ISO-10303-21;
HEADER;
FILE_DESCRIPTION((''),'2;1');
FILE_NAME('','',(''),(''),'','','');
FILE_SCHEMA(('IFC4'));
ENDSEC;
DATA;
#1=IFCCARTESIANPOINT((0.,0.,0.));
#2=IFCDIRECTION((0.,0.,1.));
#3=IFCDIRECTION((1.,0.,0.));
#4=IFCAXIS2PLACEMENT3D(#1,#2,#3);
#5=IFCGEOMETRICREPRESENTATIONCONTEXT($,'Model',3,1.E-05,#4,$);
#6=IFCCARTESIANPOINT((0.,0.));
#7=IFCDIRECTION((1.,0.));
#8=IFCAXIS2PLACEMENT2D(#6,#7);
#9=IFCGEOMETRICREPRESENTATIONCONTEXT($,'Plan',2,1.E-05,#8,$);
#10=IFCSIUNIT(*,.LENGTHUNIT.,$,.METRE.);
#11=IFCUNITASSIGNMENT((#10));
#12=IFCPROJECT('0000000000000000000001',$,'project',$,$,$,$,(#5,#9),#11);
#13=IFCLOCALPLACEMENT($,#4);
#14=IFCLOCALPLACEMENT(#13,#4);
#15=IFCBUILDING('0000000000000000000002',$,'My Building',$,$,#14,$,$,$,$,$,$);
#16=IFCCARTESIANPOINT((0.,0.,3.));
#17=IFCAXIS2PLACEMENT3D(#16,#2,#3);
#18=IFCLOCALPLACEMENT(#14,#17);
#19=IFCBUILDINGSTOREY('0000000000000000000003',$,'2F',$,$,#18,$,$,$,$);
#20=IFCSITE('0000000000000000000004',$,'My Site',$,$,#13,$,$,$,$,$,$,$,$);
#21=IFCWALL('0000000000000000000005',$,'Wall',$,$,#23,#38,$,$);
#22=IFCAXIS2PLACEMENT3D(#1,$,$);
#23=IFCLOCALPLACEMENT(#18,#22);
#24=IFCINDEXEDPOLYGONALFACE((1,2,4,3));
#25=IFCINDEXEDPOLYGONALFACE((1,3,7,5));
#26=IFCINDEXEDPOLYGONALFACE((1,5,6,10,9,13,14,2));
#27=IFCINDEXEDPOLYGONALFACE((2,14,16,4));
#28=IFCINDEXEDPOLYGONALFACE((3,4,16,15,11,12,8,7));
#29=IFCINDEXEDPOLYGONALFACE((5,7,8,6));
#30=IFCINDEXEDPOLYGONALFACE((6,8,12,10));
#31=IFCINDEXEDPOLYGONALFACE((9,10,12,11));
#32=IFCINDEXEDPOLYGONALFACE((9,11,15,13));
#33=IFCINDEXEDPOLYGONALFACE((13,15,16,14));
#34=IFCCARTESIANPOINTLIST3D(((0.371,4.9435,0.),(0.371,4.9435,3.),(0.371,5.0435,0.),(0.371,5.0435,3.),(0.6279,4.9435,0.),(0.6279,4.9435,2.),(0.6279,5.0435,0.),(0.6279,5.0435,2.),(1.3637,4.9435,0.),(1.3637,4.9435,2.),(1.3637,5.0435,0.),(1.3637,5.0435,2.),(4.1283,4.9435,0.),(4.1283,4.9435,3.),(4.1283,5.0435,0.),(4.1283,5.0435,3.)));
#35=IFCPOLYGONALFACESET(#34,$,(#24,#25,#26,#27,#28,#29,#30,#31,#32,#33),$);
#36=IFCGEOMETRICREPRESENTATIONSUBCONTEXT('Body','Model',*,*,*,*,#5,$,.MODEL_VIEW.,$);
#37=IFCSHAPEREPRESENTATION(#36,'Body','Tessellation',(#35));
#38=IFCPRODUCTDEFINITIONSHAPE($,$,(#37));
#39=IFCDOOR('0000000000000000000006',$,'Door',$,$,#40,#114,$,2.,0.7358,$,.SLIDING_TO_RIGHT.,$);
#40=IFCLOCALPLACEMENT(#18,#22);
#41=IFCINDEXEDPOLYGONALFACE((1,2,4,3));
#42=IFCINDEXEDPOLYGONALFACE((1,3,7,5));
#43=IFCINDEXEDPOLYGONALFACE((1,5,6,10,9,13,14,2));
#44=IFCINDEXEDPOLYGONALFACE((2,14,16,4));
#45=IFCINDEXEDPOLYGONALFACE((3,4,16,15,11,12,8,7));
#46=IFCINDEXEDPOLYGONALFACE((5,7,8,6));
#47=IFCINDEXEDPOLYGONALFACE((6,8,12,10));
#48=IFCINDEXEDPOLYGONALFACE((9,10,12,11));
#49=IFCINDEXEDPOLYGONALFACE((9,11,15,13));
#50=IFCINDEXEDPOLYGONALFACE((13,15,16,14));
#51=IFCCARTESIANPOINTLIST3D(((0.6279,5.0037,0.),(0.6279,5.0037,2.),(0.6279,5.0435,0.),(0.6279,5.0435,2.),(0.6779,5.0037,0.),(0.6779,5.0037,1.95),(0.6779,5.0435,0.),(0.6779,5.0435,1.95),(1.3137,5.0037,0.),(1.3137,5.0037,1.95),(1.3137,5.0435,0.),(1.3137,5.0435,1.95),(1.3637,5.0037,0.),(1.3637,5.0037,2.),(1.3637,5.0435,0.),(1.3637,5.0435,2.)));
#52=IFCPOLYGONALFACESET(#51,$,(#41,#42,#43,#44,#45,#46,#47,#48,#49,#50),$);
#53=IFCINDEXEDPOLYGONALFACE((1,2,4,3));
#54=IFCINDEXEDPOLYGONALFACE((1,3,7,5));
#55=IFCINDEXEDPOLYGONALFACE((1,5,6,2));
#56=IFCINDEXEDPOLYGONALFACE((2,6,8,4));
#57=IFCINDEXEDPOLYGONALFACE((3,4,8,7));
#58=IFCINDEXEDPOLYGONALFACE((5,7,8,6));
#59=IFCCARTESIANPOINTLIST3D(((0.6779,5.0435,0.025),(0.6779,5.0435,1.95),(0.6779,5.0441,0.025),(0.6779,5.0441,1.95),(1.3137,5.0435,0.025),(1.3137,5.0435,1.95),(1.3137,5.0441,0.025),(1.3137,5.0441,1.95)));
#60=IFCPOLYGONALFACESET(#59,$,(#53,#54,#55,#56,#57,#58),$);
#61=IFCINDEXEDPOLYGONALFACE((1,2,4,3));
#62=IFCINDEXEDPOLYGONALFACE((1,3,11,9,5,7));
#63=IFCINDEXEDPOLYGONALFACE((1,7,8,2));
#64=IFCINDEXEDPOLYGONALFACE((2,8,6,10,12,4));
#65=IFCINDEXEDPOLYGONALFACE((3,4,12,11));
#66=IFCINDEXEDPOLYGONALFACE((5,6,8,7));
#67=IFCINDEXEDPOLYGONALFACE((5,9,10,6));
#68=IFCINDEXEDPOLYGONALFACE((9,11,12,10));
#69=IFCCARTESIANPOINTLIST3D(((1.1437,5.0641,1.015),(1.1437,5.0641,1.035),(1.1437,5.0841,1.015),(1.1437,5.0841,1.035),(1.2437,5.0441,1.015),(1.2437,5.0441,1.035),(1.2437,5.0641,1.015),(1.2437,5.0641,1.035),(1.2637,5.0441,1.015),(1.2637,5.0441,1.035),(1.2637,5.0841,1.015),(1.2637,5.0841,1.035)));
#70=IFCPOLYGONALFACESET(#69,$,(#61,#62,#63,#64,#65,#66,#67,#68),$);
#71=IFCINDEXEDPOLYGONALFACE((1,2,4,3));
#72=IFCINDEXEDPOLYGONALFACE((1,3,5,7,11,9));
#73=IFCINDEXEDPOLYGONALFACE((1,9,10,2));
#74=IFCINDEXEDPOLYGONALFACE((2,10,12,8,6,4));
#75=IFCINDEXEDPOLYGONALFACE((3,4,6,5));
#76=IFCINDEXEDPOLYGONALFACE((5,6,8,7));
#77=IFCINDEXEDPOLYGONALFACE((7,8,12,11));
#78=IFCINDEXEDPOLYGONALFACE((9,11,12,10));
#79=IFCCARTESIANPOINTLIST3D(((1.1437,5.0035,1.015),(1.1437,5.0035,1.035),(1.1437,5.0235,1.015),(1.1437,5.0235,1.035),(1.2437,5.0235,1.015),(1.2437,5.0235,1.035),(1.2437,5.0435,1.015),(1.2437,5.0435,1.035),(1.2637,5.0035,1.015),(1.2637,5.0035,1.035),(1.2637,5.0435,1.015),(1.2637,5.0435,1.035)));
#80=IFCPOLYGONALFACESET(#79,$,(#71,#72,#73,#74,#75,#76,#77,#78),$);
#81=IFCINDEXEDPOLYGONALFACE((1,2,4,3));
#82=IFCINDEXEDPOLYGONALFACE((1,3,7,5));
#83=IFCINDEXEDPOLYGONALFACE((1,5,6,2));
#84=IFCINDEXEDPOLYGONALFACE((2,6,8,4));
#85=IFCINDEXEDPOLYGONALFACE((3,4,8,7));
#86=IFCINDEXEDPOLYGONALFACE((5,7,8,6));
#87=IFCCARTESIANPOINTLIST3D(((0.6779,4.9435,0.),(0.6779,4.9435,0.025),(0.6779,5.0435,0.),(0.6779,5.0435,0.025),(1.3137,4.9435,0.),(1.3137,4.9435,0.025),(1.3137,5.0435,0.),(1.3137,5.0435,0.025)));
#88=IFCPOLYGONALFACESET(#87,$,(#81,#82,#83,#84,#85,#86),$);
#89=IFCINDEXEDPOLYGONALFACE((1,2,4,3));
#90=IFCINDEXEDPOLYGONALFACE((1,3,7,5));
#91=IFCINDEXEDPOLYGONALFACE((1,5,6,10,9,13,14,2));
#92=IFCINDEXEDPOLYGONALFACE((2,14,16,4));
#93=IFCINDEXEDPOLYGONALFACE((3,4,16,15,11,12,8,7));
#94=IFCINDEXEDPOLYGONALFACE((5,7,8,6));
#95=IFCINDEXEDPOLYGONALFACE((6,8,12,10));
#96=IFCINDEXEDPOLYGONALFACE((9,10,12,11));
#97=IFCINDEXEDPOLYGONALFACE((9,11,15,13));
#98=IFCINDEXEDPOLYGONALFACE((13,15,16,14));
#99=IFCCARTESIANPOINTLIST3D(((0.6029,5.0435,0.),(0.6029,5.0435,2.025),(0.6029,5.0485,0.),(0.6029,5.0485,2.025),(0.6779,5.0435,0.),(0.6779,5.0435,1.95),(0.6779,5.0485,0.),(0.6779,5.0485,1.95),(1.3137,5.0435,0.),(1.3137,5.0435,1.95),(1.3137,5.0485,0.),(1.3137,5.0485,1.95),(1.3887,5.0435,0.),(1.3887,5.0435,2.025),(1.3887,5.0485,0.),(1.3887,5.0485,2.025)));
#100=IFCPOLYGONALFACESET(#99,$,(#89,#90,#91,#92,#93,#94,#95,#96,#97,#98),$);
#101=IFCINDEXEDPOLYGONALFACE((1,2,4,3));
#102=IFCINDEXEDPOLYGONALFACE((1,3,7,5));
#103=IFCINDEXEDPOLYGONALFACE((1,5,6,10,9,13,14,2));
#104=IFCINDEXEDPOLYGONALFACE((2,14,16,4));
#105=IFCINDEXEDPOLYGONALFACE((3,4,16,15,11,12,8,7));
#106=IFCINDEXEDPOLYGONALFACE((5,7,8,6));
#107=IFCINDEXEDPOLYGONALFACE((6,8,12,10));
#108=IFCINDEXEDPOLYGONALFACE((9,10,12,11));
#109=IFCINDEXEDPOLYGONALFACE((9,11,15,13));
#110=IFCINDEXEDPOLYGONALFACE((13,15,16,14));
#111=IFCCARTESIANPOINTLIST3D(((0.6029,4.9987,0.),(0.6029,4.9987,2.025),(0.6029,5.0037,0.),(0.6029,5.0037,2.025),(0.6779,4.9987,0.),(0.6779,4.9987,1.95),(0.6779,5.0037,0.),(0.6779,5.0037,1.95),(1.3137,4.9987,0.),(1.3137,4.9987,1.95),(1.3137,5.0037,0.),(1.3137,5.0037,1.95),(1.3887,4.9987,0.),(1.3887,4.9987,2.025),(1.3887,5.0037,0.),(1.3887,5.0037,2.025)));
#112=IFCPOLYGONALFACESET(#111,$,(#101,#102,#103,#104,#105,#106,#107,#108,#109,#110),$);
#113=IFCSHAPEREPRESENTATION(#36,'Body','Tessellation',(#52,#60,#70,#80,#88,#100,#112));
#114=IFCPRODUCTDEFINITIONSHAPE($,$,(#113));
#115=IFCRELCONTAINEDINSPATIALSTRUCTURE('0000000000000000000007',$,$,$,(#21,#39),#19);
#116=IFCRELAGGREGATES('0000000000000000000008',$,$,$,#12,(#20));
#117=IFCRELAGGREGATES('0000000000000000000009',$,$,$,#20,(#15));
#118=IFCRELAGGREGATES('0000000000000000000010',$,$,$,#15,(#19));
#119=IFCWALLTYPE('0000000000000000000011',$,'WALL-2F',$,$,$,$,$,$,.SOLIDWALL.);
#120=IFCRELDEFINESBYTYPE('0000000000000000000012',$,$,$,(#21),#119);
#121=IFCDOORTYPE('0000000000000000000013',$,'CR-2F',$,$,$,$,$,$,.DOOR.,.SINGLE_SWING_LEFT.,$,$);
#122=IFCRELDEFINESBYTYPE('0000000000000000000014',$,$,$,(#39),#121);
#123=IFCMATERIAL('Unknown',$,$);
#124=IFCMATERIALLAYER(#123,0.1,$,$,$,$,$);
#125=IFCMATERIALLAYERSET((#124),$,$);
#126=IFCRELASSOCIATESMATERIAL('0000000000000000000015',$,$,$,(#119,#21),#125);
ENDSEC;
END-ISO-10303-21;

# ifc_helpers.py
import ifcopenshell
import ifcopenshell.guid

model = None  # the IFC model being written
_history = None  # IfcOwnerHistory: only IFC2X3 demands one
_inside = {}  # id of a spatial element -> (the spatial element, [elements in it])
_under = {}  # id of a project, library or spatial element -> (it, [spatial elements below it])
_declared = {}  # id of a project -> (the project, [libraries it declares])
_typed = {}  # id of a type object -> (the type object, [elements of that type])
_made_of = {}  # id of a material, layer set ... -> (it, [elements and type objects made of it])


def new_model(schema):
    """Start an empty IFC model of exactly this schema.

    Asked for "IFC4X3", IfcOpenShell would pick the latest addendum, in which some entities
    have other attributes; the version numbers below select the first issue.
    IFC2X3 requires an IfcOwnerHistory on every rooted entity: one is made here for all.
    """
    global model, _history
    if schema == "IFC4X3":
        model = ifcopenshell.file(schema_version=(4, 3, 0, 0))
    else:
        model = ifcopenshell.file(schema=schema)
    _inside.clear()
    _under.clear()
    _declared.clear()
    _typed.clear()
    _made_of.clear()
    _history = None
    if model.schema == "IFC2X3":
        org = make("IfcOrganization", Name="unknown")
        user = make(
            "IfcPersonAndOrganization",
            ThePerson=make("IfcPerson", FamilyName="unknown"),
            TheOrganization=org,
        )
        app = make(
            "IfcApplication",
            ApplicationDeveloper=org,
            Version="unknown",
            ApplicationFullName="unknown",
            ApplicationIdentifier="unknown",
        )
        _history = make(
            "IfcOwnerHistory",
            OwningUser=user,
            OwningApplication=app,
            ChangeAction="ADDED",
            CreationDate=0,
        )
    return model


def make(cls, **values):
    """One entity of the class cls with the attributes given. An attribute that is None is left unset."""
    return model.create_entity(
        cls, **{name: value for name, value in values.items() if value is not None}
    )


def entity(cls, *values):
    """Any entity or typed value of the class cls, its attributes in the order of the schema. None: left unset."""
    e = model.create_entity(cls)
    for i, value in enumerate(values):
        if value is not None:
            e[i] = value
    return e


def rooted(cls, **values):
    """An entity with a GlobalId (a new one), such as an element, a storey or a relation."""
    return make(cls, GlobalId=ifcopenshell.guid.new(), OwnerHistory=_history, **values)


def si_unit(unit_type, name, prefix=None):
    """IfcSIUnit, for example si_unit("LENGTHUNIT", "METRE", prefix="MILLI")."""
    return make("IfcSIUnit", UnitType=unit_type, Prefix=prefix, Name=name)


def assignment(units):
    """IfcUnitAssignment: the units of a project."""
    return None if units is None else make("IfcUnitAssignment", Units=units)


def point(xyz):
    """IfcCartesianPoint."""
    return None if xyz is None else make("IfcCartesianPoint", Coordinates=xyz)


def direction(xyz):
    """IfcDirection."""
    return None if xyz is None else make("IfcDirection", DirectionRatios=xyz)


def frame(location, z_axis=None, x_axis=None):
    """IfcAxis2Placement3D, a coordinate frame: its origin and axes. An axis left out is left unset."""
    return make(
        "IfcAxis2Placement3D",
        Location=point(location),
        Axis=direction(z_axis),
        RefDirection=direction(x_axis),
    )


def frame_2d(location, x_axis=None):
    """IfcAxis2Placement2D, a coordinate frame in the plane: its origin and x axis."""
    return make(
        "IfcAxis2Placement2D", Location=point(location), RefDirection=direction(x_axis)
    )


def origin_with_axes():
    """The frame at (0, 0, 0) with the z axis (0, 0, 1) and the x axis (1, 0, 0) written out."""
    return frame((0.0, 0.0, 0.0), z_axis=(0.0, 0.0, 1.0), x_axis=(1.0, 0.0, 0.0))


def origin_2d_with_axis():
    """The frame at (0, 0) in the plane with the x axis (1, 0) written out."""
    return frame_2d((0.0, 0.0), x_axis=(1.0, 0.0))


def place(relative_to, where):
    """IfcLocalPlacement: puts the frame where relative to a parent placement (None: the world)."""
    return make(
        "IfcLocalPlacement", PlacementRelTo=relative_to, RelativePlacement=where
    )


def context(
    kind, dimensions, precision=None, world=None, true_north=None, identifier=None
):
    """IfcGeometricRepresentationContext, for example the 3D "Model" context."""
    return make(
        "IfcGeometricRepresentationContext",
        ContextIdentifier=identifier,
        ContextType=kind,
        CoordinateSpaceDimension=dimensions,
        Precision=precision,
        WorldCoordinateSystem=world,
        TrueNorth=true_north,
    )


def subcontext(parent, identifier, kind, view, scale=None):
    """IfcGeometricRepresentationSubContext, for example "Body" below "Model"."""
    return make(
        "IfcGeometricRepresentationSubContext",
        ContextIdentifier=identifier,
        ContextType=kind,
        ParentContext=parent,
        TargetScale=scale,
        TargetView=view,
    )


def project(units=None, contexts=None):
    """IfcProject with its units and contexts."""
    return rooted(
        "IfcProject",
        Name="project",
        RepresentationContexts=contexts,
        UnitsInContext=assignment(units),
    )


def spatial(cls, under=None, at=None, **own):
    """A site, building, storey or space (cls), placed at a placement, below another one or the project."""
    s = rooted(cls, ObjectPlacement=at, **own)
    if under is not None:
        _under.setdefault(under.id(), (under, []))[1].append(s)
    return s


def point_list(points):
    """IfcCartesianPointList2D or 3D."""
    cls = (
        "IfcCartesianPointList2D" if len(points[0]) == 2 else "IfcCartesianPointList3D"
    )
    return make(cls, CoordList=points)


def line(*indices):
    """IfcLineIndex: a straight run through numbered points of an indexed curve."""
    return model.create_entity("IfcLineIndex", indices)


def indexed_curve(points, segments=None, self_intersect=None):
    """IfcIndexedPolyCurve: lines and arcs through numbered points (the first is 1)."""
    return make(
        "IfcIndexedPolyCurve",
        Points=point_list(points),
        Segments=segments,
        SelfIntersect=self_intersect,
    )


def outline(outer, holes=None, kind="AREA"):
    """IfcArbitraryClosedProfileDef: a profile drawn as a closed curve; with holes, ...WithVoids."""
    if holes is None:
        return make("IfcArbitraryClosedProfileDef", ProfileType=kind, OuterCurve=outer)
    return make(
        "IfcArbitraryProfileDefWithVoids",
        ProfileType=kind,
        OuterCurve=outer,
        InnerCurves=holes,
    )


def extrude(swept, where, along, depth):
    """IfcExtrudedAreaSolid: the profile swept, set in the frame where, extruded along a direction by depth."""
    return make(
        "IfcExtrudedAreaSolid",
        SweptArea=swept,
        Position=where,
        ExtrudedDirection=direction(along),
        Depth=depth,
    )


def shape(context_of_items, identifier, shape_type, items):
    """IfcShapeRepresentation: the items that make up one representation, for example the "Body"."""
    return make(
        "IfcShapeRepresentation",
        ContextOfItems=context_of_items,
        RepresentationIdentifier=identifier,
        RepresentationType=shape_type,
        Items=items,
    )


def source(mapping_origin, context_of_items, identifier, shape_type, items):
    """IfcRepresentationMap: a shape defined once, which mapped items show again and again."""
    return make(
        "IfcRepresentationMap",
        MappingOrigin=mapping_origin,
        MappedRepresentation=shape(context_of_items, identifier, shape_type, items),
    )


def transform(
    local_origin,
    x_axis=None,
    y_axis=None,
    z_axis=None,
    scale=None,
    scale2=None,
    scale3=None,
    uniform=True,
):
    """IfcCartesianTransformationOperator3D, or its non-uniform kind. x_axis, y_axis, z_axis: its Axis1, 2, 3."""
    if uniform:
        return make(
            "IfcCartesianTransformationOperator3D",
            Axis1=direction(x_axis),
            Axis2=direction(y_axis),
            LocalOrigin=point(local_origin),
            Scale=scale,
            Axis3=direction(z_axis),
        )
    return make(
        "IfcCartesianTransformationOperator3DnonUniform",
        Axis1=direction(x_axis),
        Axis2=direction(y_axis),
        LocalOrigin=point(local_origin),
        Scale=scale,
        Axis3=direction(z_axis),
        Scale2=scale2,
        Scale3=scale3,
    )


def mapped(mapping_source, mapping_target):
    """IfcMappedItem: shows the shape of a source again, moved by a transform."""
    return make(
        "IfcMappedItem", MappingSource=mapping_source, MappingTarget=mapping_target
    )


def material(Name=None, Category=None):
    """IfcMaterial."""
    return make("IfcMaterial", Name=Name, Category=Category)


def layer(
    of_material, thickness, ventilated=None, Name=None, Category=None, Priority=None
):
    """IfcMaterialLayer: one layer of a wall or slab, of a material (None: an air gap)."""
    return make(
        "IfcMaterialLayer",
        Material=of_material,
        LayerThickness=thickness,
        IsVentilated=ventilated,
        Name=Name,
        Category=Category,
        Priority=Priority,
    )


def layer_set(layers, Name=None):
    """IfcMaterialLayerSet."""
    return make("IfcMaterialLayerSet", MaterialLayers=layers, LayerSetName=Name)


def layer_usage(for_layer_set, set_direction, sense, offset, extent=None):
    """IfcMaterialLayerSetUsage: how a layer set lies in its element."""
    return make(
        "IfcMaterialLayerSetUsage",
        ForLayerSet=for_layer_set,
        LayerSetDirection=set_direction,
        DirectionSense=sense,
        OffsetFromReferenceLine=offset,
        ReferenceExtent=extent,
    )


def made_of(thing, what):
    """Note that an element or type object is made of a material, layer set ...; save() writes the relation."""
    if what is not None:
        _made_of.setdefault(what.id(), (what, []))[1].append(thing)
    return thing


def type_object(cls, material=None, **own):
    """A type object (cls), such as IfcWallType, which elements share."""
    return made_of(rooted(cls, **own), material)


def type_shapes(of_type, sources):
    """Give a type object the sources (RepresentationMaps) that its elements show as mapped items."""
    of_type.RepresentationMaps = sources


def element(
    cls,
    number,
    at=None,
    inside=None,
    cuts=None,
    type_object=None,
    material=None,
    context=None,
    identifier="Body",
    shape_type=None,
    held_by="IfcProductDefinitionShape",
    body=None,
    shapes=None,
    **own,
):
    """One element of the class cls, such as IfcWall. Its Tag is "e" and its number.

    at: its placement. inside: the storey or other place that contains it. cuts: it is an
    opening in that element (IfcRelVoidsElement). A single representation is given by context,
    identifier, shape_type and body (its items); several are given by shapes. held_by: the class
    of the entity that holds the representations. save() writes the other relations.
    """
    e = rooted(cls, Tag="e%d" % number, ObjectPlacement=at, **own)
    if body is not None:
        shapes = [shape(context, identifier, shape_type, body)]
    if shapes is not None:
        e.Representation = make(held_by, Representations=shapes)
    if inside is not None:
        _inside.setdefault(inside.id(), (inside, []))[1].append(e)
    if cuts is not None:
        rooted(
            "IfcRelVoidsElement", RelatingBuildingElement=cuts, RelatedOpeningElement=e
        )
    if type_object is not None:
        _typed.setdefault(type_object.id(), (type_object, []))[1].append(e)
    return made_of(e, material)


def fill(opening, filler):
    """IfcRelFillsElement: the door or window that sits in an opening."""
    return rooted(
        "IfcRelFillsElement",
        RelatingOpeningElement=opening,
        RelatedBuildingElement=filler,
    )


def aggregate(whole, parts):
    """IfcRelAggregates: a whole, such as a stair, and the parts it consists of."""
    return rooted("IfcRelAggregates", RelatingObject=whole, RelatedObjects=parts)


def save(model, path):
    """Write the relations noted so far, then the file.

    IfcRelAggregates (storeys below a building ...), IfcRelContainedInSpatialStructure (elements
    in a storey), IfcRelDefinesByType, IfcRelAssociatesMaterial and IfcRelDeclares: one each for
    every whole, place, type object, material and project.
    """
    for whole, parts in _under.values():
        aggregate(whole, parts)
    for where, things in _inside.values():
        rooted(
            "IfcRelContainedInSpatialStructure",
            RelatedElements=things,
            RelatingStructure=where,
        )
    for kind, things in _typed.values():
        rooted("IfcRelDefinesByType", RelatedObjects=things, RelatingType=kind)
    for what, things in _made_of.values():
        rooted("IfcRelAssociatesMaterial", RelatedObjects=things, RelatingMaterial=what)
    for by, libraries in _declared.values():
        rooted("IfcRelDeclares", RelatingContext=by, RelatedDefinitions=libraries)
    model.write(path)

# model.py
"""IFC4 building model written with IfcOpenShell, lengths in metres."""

from ifc_helpers import new_model, entity, si_unit, frame, origin_with_axes, origin_2d_with_axis, place, context, subcontext, project, spatial, line, indexed_curve, outline, extrude, shape, source, transform, mapped, material, layer, layer_set, layer_usage, type_object, type_shapes, element, fill, save


model = new_model("IFC4")

# Units and contexts
model_context = context("Model", 3, precision=1e-05, world=origin_with_axes())
plan_context = context("Plan", 2, precision=1e-05, world=origin_2d_with_axis())
body_context_1 = subcontext(model_context, "Body", "Model", "MODEL_VIEW")
body_context_2 = subcontext(plan_context, "Body", "Plan", "PLAN_VIEW")
ifc_project = project(units=[si_unit("LENGTHUNIT", "METRE")], contexts=[model_context, plan_context])

# Site, building, storey
site_placement = place(None, origin_with_axes())
site = spatial("IfcSite", under=ifc_project, at=site_placement, Name="My Site")
building_placement = place(site_placement, origin_with_axes())
building = spatial("IfcBuilding", under=site, at=building_placement, Name="My Building")
storey_placement = place(building_placement, frame((0.0, 0.0, 3.0), z_axis=(0.0, 0.0, 1.0), x_axis=(1.0, 0.0, 0.0)))
storey = spatial("IfcBuildingStorey", under=building, at=storey_placement, Name="2F")

# Shared definitions
ifc_material = material(Name="Unknown")

# Shared definitions
ifc_layer_1 = layer(ifc_material, 0.1)
ifc_layer_set_1 = layer_set([ifc_layer_1])
wall_type = type_object("IfcWallType", Name="WALL-2F", PredefinedType="SOLIDWALL", material=ifc_layer_set_1)

# Wall, opening, door
ifc_layer_usage_1 = layer_usage(ifc_layer_set_1, "AXIS2", "POSITIVE", 0.0)
wall_1_placement = place(storey_placement, frame((4.2283, 5.0435, 0.0), z_axis=(0.0, 0.0, 1.0), x_axis=(-1.0, 0.0, 0.0)))
wall_1 = element("IfcWall", 1, at=wall_1_placement, inside=storey, type_object=wall_type, material=ifc_layer_usage_1, Name="Wall", context=body_context_1, shape_type="SweptSolid", body=[
    extrude(outline(indexed_curve([(0.1, 0.0), (0.1, 0.1), (3.8573, 0.1), (3.8573, 0.0)], segments=[line(1, 2, 3, 4, 1)])), origin_with_axes(), (0.0, 0.0, 1.0), 3.0),
])
shared_shape_1 = source(origin_with_axes(), body_context_1, "Body", "SweptSolid", [
    extrude(outline(indexed_curve([(0.0, 0.0), (0.7358, 0.0), (0.7358, 2.0), (0.0, 2.0)], segments=[line(1, 2, 3, 4, 1)])), frame((0.0, -0.6, 0.0), z_axis=(0.0, -1.0, 0.0), x_axis=(1.0, 0.0, 0.0)), (0.0, 0.0, -1.0), 1.2),
])
opening_1_placement = place(wall_1_placement, frame((2.8646, 0.0, 0.0), z_axis=(0.0, 0.0, 1.0), x_axis=(1.0, 0.0, 0.0)))
opening_1 = element("IfcOpeningElement", 2, at=opening_1_placement, cuts=wall_1, PredefinedType="OPENING", context=body_context_1, shape_type="MappedRepresentation", body=[
    mapped(shared_shape_1, transform((0.0, 0.0, 0.0), x_axis=(1.0, 0.0, 0.0), y_axis=(0.0, 1.0, 0.0), z_axis=(0.0, 0.0, 1.0), scale=1.0)),
])
door_type_1 = type_object("IfcDoorType", Name="CR-2F", OperationType="SINGLE_SWING_LEFT", PredefinedType="DOOR")
shared_shape_2 = source(origin_with_axes(), body_context_1, "Body", "SweptSolid", [
    extrude(outline(indexed_curve([(0.0, 0.0), (0.0, 2.0), (0.7358, 2.0), (0.7358, 0.0), (0.6858, 0.0), (0.6858, 1.95), (0.05, 1.95), (0.05, 0.0)], segments=[line(1, 2, 3, 4, 5, 6, 7, 8, 1)])), frame((0.0, 0.0, 0.0), z_axis=(0.0, -1.0, 0.0), x_axis=(1.0, 0.0, 0.0)), (0.0, 0.0, -1.0), 0.0398),
    extrude(outline(indexed_curve([(0.0, 0.0), (0.6358, 0.0), (0.6358, 0.0006), (0.0, 0.0006)], segments=[line(1, 2, 3, 4, 1)])), frame((0.05, -0.0006, 0.025), z_axis=(0.0, 0.0, 1.0), x_axis=(1.0, 0.0, 0.0)), (0.0, 0.0, 1.0), 1.925),
    extrude(outline(indexed_curve([(0.0, 0.0), (0.0, -0.04), (0.12, -0.04), (0.12, -0.02), (0.02, -0.02), (0.02, 0.0)], segments=[line(1, 2, 3, 4, 5, 6, 1)])), frame((0.1, -0.0006, 1.015), z_axis=(0.0, 0.0, 1.0), x_axis=(1.0, 0.0, 0.0)), (0.0, 0.0, 1.0), 0.02),
    extrude(outline(indexed_curve([(0.0, 0.0), (0.0, 0.04), (0.12, 0.04), (0.12, 0.02), (0.02, 0.02), (0.02, 0.0)], segments=[line(1, 2, 3, 4, 5, 6, 1)])), frame((0.1, 0.0, 1.015), z_axis=(0.0, 0.0, 1.0), x_axis=(1.0, 0.0, 0.0)), (0.0, 0.0, 1.0), 0.02),
    extrude(outline(indexed_curve([(0.0, 0.0), (0.6358, 0.0), (0.6358, 0.1), (0.0, 0.1)], segments=[line(1, 2, 3, 4, 1)])), frame((0.05, 0.0, 0.0), z_axis=(0.0, 0.0, 1.0), x_axis=(1.0, 0.0, 0.0)), (0.0, 0.0, 1.0), 0.025),
    extrude(outline(indexed_curve([(0.0, 0.0), (0.0, 2.025), (0.7858, 2.025), (0.7858, 0.0), (0.7108, 0.0), (0.7108, 1.95), (0.075, 1.95), (0.075, 0.0)], segments=[line(1, 2, 3, 4, 5, 6, 7, 8, 1)])), frame((-0.025, -0.005, 0.0), z_axis=(0.0, -1.0, 0.0), x_axis=(1.0, 0.0, 0.0)), (0.0, 0.0, -1.0), 0.005),
    extrude(outline(indexed_curve([(0.0, 0.0), (0.0, 2.025), (0.7858, 2.025), (0.7858, 0.0), (0.7108, 0.0), (0.7108, 1.95), (0.075, 1.95), (0.075, 0.0)], segments=[line(1, 2, 3, 4, 5, 6, 7, 8, 1)])), frame((-0.025, 0.0398, 0.0), z_axis=(0.0, -1.0, 0.0), x_axis=(1.0, 0.0, 0.0)), (0.0, 0.0, -1.0), 0.005),
])
shared_shape_3 = source(origin_with_axes(), body_context_2, "Body", "Curve2D", [
    entity("IfcIndexedPolyCurve", entity("IfcCartesianPointList2D", [[0.0, 0.0], [0.05, 0.0], [0.05, 0.0398], [0.0, 0.0398]]), [entity("IfcLineIndex", [1, 2, 3, 4, 1])]),
    entity("IfcIndexedPolyCurve", entity("IfcCartesianPointList2D", [[0.7358, 0.0], [0.6858, 0.0], [0.6858, 0.0398], [0.7358, 0.0398]]), [entity("IfcLineIndex", [1, 2, 3, 4, 1])]),
    entity("IfcIndexedPolyCurve", entity("IfcCartesianPointList2D", [[1.0037, -0.0006], [0.3679, -0.0006], [0.3679, 0.0], [1.0037, 0.0]]), [entity("IfcLineIndex", [1, 2, 3, 4, 1])]),
])
type_shapes(door_type_1, [shared_shape_2, shared_shape_3])
door_1_placement = place(opening_1_placement, frame((0.0, 0.0, 0.0), z_axis=(0.0, 0.0, 1.0), x_axis=(1.0, 0.0, 0.0)))
door_1 = element("IfcDoor", 3, at=door_1_placement, inside=storey, type_object=door_type_1, Name="Door", OperationType="SLIDING_TO_RIGHT", OverallHeight=2.0, OverallWidth=0.7358, shapes=[
    shape(body_context_1, "Body", "MappedRepresentation", [mapped(shared_shape_2, transform((0.0, 0.0, 0.0), x_axis=(1.0, 0.0, 0.0), y_axis=(0.0, 1.0, 0.0), z_axis=(0.0, 0.0, 1.0), scale=1.0))]),
    shape(body_context_2, "Body", "MappedRepresentation", [mapped(shared_shape_3, transform((0.0, 0.0, 0.0), x_axis=(1.0, 0.0, 0.0), y_axis=(0.0, 1.0, 0.0), z_axis=(0.0, 0.0, 1.0), scale=1.0))]),
])
fill(opening_1, door_1)

save(model, "model.ifc")
